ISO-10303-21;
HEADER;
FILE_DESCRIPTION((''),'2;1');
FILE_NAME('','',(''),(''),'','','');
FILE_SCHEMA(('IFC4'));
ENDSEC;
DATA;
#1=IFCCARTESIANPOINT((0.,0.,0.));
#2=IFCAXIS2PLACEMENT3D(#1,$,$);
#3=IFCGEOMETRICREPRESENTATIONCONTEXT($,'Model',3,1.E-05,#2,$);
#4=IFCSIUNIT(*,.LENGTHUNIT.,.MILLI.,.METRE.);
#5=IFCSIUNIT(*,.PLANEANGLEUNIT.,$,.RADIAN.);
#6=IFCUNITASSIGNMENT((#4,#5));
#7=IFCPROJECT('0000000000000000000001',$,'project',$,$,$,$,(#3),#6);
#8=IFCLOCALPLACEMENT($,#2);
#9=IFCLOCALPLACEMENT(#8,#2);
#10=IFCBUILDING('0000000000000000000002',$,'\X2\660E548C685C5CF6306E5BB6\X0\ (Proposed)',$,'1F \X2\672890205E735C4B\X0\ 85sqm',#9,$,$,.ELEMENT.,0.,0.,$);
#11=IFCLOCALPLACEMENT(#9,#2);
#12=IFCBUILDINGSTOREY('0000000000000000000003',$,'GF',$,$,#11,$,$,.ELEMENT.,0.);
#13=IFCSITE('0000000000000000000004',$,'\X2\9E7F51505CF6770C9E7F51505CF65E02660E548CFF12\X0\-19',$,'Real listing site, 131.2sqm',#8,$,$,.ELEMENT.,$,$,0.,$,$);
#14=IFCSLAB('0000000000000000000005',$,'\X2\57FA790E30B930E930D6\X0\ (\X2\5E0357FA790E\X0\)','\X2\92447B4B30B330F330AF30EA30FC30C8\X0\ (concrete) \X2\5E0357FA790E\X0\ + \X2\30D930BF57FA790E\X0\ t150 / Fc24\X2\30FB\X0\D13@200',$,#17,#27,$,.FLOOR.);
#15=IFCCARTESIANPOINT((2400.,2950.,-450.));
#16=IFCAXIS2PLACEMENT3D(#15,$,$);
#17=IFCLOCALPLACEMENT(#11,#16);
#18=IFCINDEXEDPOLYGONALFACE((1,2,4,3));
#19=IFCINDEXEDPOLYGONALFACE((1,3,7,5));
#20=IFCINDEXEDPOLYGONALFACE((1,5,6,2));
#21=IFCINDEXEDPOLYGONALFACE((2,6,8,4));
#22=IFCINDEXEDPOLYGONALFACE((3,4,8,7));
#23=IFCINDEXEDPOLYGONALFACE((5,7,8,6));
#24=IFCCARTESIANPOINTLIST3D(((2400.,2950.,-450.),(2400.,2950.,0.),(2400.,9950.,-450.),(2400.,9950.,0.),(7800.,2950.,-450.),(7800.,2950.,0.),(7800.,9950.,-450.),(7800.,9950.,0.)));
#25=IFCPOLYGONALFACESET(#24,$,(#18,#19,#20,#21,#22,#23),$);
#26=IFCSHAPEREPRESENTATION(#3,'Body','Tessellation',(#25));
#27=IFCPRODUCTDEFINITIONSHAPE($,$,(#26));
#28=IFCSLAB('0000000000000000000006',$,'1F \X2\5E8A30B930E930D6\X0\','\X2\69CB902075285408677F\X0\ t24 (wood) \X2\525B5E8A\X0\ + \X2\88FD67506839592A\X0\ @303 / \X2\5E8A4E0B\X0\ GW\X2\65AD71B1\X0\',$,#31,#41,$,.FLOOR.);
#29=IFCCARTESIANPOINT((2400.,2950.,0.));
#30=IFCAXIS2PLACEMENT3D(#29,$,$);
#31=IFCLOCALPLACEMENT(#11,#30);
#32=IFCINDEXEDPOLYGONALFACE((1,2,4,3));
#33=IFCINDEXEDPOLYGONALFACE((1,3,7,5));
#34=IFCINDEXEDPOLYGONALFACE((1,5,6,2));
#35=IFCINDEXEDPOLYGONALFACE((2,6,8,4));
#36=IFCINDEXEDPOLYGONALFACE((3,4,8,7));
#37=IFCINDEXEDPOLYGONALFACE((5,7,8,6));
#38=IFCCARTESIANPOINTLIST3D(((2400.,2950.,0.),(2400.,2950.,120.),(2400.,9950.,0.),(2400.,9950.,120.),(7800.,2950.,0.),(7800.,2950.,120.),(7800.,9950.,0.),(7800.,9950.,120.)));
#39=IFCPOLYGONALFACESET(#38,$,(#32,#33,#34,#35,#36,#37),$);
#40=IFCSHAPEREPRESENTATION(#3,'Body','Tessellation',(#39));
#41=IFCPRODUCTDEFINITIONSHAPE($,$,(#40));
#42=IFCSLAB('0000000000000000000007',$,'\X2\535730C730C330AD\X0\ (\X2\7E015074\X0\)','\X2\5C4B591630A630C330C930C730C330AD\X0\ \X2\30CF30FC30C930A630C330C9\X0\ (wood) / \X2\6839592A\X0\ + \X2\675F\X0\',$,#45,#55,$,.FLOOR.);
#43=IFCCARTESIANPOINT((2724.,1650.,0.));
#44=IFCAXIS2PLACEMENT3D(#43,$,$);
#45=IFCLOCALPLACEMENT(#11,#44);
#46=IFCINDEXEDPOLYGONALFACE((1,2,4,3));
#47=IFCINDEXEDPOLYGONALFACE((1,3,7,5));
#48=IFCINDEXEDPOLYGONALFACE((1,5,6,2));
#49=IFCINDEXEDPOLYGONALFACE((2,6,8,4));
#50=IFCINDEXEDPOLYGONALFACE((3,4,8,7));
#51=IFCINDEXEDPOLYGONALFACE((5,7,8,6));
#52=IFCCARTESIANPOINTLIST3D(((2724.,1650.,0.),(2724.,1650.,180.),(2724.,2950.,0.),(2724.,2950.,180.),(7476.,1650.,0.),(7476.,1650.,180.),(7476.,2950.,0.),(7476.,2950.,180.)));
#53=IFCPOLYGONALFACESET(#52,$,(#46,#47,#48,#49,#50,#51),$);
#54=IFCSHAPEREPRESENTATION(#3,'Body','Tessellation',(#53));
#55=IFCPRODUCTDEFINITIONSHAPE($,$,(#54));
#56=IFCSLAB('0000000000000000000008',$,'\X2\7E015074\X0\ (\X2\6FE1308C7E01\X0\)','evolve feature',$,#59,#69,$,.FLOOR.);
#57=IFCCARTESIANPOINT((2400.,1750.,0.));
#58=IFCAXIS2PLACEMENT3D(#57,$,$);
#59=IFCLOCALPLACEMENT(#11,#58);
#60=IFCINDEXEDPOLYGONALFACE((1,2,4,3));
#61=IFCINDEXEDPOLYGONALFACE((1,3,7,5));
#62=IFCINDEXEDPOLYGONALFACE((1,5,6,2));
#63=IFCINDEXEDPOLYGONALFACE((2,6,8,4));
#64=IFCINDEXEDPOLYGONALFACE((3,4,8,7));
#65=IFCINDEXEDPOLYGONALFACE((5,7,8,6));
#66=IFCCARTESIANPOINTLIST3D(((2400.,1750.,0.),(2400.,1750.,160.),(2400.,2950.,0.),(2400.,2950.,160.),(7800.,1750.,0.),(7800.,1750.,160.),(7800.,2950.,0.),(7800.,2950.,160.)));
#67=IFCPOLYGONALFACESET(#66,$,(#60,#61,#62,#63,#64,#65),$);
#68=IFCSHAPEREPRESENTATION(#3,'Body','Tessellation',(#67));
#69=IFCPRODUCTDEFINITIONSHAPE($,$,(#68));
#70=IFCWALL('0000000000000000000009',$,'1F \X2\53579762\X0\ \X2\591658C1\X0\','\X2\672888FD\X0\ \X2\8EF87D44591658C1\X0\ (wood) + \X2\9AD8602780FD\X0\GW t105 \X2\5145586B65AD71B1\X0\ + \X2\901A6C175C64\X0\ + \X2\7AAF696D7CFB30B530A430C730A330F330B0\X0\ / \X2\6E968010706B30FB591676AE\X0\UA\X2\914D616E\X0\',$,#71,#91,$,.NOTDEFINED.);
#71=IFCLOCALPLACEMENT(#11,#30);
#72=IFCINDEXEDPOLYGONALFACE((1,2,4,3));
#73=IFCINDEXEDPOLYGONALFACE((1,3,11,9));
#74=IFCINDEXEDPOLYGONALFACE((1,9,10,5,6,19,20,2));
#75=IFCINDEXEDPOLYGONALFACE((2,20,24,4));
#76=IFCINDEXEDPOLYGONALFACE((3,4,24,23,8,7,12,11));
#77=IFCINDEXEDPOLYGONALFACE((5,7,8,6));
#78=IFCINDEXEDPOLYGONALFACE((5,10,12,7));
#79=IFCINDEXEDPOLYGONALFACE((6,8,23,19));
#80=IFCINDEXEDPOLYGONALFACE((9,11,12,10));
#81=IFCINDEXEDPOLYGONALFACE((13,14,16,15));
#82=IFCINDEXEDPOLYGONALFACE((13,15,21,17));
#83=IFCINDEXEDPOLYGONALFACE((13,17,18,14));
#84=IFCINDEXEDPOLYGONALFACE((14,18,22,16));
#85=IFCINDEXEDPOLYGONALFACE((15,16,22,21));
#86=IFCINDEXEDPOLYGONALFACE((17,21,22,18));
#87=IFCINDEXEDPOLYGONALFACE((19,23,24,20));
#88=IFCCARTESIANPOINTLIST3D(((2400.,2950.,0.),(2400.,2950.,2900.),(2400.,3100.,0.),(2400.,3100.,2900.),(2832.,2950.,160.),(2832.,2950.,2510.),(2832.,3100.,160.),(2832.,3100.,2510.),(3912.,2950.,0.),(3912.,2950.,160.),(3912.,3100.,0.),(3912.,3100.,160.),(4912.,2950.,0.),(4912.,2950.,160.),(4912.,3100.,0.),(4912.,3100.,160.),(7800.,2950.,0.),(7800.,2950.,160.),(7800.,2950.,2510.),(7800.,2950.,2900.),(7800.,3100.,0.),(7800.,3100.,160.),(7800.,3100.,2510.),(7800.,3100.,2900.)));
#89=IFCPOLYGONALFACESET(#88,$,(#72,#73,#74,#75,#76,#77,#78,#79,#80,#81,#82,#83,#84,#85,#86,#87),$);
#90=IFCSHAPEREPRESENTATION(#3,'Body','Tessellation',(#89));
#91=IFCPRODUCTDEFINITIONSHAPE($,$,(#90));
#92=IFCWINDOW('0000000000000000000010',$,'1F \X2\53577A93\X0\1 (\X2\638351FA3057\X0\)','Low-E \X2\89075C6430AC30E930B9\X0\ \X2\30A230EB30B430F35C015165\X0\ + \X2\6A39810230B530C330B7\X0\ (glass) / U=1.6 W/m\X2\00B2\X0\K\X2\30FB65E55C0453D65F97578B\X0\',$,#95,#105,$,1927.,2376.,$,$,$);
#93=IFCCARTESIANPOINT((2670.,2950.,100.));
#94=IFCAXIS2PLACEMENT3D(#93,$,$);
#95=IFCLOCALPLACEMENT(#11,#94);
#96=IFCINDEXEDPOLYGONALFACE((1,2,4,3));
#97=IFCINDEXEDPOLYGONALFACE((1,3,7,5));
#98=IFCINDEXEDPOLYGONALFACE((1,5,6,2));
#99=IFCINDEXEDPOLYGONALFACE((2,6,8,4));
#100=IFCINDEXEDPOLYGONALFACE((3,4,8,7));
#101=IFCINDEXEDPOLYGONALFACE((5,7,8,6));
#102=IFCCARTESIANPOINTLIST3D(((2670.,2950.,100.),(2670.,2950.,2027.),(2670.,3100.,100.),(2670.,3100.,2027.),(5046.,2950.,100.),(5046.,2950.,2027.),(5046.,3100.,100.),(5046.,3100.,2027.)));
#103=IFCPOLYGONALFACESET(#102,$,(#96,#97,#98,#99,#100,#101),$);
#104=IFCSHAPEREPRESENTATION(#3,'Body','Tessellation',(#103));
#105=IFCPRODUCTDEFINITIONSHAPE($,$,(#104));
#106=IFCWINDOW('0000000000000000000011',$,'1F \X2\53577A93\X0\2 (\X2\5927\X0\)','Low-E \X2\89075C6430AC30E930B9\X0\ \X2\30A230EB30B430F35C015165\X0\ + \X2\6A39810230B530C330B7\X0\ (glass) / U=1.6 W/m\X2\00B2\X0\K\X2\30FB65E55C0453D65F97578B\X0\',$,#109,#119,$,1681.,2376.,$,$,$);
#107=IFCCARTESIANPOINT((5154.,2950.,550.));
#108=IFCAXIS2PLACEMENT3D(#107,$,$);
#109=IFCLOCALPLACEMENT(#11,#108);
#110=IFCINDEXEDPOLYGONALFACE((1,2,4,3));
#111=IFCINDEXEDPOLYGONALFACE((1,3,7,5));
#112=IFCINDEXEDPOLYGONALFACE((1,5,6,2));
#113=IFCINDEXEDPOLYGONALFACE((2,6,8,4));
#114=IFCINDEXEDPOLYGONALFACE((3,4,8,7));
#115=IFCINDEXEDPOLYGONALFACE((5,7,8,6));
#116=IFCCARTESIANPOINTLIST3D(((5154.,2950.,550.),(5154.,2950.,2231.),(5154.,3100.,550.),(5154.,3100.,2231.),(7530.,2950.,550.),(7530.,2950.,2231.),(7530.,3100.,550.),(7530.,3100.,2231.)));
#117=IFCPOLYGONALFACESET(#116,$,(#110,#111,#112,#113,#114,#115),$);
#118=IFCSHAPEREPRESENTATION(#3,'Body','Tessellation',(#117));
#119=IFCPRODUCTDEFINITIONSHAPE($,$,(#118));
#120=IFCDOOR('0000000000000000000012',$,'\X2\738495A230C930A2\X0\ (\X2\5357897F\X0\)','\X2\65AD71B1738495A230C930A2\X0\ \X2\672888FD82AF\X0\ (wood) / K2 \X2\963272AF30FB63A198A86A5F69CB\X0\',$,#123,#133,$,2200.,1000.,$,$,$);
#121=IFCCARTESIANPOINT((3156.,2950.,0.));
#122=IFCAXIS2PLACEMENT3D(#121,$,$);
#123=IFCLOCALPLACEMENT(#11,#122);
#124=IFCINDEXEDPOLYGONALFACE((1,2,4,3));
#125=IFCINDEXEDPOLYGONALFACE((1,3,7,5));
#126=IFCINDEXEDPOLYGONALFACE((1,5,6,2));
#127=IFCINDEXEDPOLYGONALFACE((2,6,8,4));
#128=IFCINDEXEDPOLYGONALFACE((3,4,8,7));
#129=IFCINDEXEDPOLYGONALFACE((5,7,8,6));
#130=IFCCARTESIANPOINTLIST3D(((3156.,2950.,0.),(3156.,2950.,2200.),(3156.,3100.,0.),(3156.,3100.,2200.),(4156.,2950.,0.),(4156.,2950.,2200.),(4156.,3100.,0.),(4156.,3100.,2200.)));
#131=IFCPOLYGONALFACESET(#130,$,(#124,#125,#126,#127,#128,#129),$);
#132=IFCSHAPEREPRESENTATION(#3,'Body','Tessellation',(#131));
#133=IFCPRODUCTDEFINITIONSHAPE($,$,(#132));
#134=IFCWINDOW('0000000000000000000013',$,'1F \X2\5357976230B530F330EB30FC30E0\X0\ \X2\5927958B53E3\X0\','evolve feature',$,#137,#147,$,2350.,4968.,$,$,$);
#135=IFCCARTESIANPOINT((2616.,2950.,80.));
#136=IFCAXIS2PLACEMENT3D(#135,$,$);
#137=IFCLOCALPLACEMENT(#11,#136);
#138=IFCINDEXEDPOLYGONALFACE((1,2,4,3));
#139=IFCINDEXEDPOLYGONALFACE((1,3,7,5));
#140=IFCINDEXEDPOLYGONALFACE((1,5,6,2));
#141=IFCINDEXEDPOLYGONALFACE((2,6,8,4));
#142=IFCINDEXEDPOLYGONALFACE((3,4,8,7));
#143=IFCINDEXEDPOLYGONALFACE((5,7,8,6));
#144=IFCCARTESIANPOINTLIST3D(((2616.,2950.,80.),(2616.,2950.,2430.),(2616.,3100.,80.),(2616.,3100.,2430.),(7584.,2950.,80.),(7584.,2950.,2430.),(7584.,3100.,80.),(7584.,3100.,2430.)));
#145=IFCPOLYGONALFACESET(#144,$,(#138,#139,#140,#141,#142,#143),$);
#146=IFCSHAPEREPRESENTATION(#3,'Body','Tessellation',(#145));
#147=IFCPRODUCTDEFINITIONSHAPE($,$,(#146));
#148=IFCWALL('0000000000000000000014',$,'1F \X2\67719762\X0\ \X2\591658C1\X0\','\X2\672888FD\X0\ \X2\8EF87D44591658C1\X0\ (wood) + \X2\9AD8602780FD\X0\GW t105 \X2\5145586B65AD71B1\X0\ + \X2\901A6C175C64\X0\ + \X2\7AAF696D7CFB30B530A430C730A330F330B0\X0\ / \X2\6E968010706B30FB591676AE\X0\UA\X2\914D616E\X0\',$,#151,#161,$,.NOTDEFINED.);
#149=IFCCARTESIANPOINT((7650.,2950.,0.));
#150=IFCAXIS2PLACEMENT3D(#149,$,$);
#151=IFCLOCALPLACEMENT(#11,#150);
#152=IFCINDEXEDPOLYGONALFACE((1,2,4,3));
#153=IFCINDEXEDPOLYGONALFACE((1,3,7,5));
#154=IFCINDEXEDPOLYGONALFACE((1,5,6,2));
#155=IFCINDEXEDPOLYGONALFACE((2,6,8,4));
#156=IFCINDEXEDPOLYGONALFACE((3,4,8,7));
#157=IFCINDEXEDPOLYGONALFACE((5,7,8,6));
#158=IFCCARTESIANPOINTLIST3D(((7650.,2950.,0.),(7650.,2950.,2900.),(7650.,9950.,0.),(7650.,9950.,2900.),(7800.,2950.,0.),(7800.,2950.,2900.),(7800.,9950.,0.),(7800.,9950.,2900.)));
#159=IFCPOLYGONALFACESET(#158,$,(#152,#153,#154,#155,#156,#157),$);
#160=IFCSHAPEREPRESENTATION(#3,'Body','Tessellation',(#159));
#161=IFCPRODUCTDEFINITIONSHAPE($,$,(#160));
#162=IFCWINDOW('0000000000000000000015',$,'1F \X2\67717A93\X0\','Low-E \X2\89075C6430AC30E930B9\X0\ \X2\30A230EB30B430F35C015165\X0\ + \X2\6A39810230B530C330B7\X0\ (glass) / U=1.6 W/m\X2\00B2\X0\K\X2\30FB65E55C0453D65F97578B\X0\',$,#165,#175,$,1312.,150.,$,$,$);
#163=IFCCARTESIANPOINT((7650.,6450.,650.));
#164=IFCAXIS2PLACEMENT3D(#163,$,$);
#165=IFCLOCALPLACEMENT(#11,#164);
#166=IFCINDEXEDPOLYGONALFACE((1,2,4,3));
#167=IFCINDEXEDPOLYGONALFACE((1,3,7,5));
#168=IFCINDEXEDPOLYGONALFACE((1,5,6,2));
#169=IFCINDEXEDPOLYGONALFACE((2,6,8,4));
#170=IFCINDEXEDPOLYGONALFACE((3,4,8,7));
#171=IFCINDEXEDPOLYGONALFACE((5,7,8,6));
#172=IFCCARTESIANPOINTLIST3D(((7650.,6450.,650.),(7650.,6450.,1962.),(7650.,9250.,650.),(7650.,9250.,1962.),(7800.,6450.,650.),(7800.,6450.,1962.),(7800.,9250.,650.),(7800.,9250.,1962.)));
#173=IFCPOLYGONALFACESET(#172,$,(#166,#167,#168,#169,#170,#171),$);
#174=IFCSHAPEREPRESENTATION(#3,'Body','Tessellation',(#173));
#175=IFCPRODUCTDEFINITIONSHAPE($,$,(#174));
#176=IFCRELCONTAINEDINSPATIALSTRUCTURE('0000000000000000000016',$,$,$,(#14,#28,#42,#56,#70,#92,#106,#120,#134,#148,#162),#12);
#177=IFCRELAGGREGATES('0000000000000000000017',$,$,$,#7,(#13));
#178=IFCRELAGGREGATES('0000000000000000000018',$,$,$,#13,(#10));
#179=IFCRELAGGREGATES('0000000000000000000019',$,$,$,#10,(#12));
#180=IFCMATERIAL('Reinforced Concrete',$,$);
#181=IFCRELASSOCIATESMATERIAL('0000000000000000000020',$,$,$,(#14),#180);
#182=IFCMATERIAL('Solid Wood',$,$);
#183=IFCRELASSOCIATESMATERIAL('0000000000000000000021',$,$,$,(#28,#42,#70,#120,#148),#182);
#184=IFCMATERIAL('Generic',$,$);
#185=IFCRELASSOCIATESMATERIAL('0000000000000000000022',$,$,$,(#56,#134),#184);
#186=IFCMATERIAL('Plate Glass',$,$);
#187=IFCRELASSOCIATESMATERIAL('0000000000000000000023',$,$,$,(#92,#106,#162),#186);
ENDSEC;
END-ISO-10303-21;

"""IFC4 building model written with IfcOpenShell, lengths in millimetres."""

from ifc_helpers import new_model, si_unit, frame, frame_2d, origin, place, context, project, spatial, rectangle, extrude, material, element, fill, save


model = new_model("IFC4")

# Units and contexts
model_context = context("Model", 3, precision=1e-05, world=origin())
ifc_project = project(units=[si_unit("LENGTHUNIT", "METRE", prefix="MILLI"), si_unit("PLANEANGLEUNIT", "RADIAN")], contexts=[model_context])

# Site, building, storey
site_placement = place(None, origin())
site = spatial("IfcSite", under=ifc_project, at=site_placement, Name="鹿児島県鹿児島市明和２-19", ObjectType="Real listing site, 131.2sqm", CompositionType="ELEMENT", RefElevation=0.0)
building_placement = place(site_placement, origin())
building = spatial("IfcBuilding", under=site, at=building_placement, Name="明和桜島の家 (Proposed)", ObjectType="1F 木造平屋 85sqm", CompositionType="ELEMENT", ElevationOfRefHeight=0.0, ElevationOfTerrain=0.0)
storey_placement = place(building_placement, origin())
storey = spatial("IfcBuildingStorey", under=building, at=storey_placement, Name="GF", CompositionType="ELEMENT", Elevation=0.0)

# Slabs
ifc_material_1 = material(Name="Reinforced Concrete")
slab_1_placement = place(storey_placement, frame((2400.0, 2950.0, -450.0)))
element("IfcSlab", 1, at=slab_1_placement, inside=storey, material=ifc_material_1, Name="基礎スラブ (布基礎)", Description="鉄筋コンクリート (concrete) 布基礎 + ベタ基礎 t150 / Fc24・D13@200", PredefinedType="FLOOR", context=model_context, shape_type="SweptSolid", body=[
    extrude(rectangle(XDim=5400.0, YDim=7000.0, at=frame_2d((2700.0, 3500.0))), frame((2400.0, 2950.0, -450.0)), (0.0, 0.0, 1.0), 450.0),
])
ifc_material_2 = material(Name="Solid Wood")
slab_2_placement = place(storey_placement, frame((2400.0, 2950.0, 0.0)))
element("IfcSlab", 2, at=slab_2_placement, inside=storey, material=ifc_material_2, Name="1F 床スラブ", Description="構造用合板 t24 (wood) 剛床 + 製材根太 @303 / 床下 GW断熱", PredefinedType="FLOOR", context=model_context, shape_type="SweptSolid", body=[
    extrude(rectangle(XDim=5400.0, YDim=7000.0, at=frame_2d((2700.0, 3500.0))), frame((2400.0, 2950.0, 0.0)), (0.0, 0.0, 1.0), 120.0),
])
slab_3_placement = place(storey_placement, frame((2724.0, 1650.0, 0.0)))
element("IfcSlab", 3, at=slab_3_placement, inside=storey, material=ifc_material_2, Name="南デッキ (縁側)", Description="屋外ウッドデッキ ハードウッド (wood) / 根太 + 束", PredefinedType="FLOOR", context=model_context, shape_type="SweptSolid", body=[
    extrude(rectangle(XDim=4752.0, YDim=1300.0, at=frame_2d((2376.0, 650.0))), frame((2724.0, 1650.0, 0.0)), (0.0, 0.0, 1.0), 180.0),
])
ifc_material_3 = material(Name="Generic")
slab_4_placement = place(storey_placement, frame((2400.0, 1750.0, 0.0)))
element("IfcSlab", 4, at=slab_4_placement, inside=storey, material=ifc_material_3, Name="縁側 (濡れ縁)", Description="evolve feature", PredefinedType="FLOOR", context=model_context, shape_type="SweptSolid", body=[
    extrude(rectangle(XDim=5400.0, YDim=1200.0, at=frame_2d((2700.0, 600.0))), frame((2400.0, 1750.0, 0.0)), (0.0, 0.0, 1.0), 160.0),
])

# Wall, openings, windows, door
wall_1_placement = place(storey_placement, frame((2400.0, 2950.0, 0.0)))
wall_1 = element("IfcWall", 5, at=wall_1_placement, inside=storey, material=ifc_material_2, Name="1F 南面 外壁", Description="木製 軸組外壁 (wood) + 高性能GW t105 充填断熱 + 通気層 + 窯業系サイディング / 準耐火・外皮UA配慮", PredefinedType="NOTDEFINED", context=model_context, shape_type="SweptSolid", body=[
    extrude(rectangle(XDim=5400.0, YDim=150.0, at=frame_2d((2700.0, 75.0))), frame((2400.0, 2950.0, 0.0)), (0.0, 0.0, 1.0), 2900.0),
])
opening_1_placement = place(storey_placement, frame((2670.0, 2950.0, 100.0)))
opening_1 = element("IfcOpeningElement", 6, at=opening_1_placement, cuts=wall_1, PredefinedType="NOTDEFINED", context=model_context, shape_type="SweptSolid", body=[
    extrude(rectangle(XDim=2376.0, YDim=150.0, at=frame_2d((1188.0, 75.0))), frame((2670.0, 2950.0, 100.0)), (0.0, 0.0, 1.0), 1927.0),
])
opening_2_placement = place(storey_placement, frame((5154.0, 2950.0, 550.0)))
opening_2 = element("IfcOpeningElement", 7, at=opening_2_placement, cuts=wall_1, PredefinedType="NOTDEFINED", context=model_context, shape_type="SweptSolid", body=[
    extrude(rectangle(XDim=2376.0, YDim=150.0, at=frame_2d((1188.0, 75.0))), frame((5154.0, 2950.0, 550.0)), (0.0, 0.0, 1.0), 1681.0),
])
opening_3_placement = place(storey_placement, frame((3156.0, 2950.0, 0.0)))
opening_3 = element("IfcOpeningElement", 8, at=opening_3_placement, cuts=wall_1, PredefinedType="NOTDEFINED", context=model_context, shape_type="SweptSolid", body=[
    extrude(rectangle(XDim=1000.0, YDim=150.0, at=frame_2d((500.0, 75.0))), frame((3156.0, 2950.0, 0.0)), (0.0, 0.0, 1.0), 2200.0),
])
opening_4_placement = place(storey_placement, frame((2616.0, 2950.0, 80.0)))
opening_4 = element("IfcOpeningElement", 9, at=opening_4_placement, cuts=wall_1, PredefinedType="NOTDEFINED", context=model_context, shape_type="SweptSolid", body=[
    extrude(rectangle(XDim=4968.0, YDim=150.0, at=frame_2d((2484.0, 75.0))), frame((2616.0, 2950.0, 80.0)), (0.0, 0.0, 1.0), 2350.0),
])
ifc_material_4 = material(Name="Plate Glass")
window_1_placement = place(storey_placement, frame((2670.0, 2950.0, 100.0)))
window_1 = element("IfcWindow", 10, at=window_1_placement, inside=storey, material=ifc_material_4, Name="1F 南窓1 (掃出し)", Description="Low-E 複層ガラス アルゴン封入 + 樹脂サッシ (glass) / U=1.6 W/m²K・日射取得型", OverallHeight=1927.0, OverallWidth=2376.0, context=model_context, shape_type="SweptSolid", body=[
    extrude(rectangle(XDim=2376.0, YDim=150.0, at=frame_2d((1188.0, 75.0))), frame((2670.0, 2950.0, 100.0)), (0.0, 0.0, 1.0), 1927.0),
])
fill(opening_1, window_1)
window_2_placement = place(storey_placement, frame((5154.0, 2950.0, 550.0)))
window_2 = element("IfcWindow", 11, at=window_2_placement, inside=storey, material=ifc_material_4, Name="1F 南窓2 (大)", Description="Low-E 複層ガラス アルゴン封入 + 樹脂サッシ (glass) / U=1.6 W/m²K・日射取得型", OverallHeight=1681.0, OverallWidth=2376.0, context=model_context, shape_type="SweptSolid", body=[
    extrude(rectangle(XDim=2376.0, YDim=150.0, at=frame_2d((1188.0, 75.0))), frame((5154.0, 2950.0, 550.0)), (0.0, 0.0, 1.0), 1681.0),
])
fill(opening_2, window_2)
door_placement = place(storey_placement, frame((3156.0, 2950.0, 0.0)))
door = element("IfcDoor", 12, at=door_placement, inside=storey, material=ifc_material_2, Name="玄関ドア (南西)", Description="断熱玄関ドア 木製芯 (wood) / K2 防犯・採風機構", OverallHeight=2200.0, OverallWidth=1000.0, context=model_context, shape_type="SweptSolid", body=[
    extrude(rectangle(XDim=1000.0, YDim=150.0, at=frame_2d((500.0, 75.0))), frame((3156.0, 2950.0, 0.0)), (0.0, 0.0, 1.0), 2200.0),
])
fill(opening_3, door)
window_3_placement = place(storey_placement, frame((2616.0, 2950.0, 80.0)))
window_3 = element("IfcWindow", 13, at=window_3_placement, inside=storey, material=ifc_material_3, Name="1F 南面サンルーム 大開口", Description="evolve feature", OverallHeight=2350.0, OverallWidth=4968.0, context=model_context, shape_type="SweptSolid", body=[
    extrude(rectangle(XDim=4968.0, YDim=150.0, at=frame_2d((2484.0, 75.0))), frame((2616.0, 2950.0, 80.0)), (0.0, 0.0, 1.0), 2350.0),
])
fill(opening_4, window_3)

# Wall, opening, window
wall_2_placement = place(storey_placement, frame((7650.0, 2950.0, 0.0)))
wall_2 = element("IfcWall", 14, at=wall_2_placement, inside=storey, material=ifc_material_2, Name="1F 東面 外壁", Description="木製 軸組外壁 (wood) + 高性能GW t105 充填断熱 + 通気層 + 窯業系サイディング / 準耐火・外皮UA配慮", PredefinedType="NOTDEFINED", context=model_context, shape_type="SweptSolid", body=[
    extrude(rectangle(XDim=150.0, YDim=7000.0, at=frame_2d((75.0, 3500.0))), frame((7650.0, 2950.0, 0.0)), (0.0, 0.0, 1.0), 2900.0),
])
opening_5_placement = place(storey_placement, frame((7650.0, 6450.0, 650.0)))
opening_5 = element("IfcOpeningElement", 15, at=opening_5_placement, cuts=wall_2, PredefinedType="NOTDEFINED", context=model_context, shape_type="SweptSolid", body=[
    extrude(rectangle(XDim=150.0, YDim=2800.0, at=frame_2d((75.0, 1400.0))), frame((7650.0, 6450.0, 650.0)), (0.0, 0.0, 1.0), 1312.0),
])
window_4_placement = place(storey_placement, frame((7650.0, 6450.0, 650.0)))
window_4 = element("IfcWindow", 16, at=window_4_placement, inside=storey, material=ifc_material_4, Name="1F 東窓", Description="Low-E 複層ガラス アルゴン封入 + 樹脂サッシ (glass) / U=1.6 W/m²K・日射取得型", OverallHeight=1312.0, OverallWidth=150.0, context=model_context, shape_type="SweptSolid", body=[
    extrude(rectangle(XDim=150.0, YDim=2800.0, at=frame_2d((75.0, 1400.0))), frame((7650.0, 6450.0, 650.0)), (0.0, 0.0, 1.0), 1312.0),
])
fill(opening_5, window_4)

save(model, "model.ifc")
